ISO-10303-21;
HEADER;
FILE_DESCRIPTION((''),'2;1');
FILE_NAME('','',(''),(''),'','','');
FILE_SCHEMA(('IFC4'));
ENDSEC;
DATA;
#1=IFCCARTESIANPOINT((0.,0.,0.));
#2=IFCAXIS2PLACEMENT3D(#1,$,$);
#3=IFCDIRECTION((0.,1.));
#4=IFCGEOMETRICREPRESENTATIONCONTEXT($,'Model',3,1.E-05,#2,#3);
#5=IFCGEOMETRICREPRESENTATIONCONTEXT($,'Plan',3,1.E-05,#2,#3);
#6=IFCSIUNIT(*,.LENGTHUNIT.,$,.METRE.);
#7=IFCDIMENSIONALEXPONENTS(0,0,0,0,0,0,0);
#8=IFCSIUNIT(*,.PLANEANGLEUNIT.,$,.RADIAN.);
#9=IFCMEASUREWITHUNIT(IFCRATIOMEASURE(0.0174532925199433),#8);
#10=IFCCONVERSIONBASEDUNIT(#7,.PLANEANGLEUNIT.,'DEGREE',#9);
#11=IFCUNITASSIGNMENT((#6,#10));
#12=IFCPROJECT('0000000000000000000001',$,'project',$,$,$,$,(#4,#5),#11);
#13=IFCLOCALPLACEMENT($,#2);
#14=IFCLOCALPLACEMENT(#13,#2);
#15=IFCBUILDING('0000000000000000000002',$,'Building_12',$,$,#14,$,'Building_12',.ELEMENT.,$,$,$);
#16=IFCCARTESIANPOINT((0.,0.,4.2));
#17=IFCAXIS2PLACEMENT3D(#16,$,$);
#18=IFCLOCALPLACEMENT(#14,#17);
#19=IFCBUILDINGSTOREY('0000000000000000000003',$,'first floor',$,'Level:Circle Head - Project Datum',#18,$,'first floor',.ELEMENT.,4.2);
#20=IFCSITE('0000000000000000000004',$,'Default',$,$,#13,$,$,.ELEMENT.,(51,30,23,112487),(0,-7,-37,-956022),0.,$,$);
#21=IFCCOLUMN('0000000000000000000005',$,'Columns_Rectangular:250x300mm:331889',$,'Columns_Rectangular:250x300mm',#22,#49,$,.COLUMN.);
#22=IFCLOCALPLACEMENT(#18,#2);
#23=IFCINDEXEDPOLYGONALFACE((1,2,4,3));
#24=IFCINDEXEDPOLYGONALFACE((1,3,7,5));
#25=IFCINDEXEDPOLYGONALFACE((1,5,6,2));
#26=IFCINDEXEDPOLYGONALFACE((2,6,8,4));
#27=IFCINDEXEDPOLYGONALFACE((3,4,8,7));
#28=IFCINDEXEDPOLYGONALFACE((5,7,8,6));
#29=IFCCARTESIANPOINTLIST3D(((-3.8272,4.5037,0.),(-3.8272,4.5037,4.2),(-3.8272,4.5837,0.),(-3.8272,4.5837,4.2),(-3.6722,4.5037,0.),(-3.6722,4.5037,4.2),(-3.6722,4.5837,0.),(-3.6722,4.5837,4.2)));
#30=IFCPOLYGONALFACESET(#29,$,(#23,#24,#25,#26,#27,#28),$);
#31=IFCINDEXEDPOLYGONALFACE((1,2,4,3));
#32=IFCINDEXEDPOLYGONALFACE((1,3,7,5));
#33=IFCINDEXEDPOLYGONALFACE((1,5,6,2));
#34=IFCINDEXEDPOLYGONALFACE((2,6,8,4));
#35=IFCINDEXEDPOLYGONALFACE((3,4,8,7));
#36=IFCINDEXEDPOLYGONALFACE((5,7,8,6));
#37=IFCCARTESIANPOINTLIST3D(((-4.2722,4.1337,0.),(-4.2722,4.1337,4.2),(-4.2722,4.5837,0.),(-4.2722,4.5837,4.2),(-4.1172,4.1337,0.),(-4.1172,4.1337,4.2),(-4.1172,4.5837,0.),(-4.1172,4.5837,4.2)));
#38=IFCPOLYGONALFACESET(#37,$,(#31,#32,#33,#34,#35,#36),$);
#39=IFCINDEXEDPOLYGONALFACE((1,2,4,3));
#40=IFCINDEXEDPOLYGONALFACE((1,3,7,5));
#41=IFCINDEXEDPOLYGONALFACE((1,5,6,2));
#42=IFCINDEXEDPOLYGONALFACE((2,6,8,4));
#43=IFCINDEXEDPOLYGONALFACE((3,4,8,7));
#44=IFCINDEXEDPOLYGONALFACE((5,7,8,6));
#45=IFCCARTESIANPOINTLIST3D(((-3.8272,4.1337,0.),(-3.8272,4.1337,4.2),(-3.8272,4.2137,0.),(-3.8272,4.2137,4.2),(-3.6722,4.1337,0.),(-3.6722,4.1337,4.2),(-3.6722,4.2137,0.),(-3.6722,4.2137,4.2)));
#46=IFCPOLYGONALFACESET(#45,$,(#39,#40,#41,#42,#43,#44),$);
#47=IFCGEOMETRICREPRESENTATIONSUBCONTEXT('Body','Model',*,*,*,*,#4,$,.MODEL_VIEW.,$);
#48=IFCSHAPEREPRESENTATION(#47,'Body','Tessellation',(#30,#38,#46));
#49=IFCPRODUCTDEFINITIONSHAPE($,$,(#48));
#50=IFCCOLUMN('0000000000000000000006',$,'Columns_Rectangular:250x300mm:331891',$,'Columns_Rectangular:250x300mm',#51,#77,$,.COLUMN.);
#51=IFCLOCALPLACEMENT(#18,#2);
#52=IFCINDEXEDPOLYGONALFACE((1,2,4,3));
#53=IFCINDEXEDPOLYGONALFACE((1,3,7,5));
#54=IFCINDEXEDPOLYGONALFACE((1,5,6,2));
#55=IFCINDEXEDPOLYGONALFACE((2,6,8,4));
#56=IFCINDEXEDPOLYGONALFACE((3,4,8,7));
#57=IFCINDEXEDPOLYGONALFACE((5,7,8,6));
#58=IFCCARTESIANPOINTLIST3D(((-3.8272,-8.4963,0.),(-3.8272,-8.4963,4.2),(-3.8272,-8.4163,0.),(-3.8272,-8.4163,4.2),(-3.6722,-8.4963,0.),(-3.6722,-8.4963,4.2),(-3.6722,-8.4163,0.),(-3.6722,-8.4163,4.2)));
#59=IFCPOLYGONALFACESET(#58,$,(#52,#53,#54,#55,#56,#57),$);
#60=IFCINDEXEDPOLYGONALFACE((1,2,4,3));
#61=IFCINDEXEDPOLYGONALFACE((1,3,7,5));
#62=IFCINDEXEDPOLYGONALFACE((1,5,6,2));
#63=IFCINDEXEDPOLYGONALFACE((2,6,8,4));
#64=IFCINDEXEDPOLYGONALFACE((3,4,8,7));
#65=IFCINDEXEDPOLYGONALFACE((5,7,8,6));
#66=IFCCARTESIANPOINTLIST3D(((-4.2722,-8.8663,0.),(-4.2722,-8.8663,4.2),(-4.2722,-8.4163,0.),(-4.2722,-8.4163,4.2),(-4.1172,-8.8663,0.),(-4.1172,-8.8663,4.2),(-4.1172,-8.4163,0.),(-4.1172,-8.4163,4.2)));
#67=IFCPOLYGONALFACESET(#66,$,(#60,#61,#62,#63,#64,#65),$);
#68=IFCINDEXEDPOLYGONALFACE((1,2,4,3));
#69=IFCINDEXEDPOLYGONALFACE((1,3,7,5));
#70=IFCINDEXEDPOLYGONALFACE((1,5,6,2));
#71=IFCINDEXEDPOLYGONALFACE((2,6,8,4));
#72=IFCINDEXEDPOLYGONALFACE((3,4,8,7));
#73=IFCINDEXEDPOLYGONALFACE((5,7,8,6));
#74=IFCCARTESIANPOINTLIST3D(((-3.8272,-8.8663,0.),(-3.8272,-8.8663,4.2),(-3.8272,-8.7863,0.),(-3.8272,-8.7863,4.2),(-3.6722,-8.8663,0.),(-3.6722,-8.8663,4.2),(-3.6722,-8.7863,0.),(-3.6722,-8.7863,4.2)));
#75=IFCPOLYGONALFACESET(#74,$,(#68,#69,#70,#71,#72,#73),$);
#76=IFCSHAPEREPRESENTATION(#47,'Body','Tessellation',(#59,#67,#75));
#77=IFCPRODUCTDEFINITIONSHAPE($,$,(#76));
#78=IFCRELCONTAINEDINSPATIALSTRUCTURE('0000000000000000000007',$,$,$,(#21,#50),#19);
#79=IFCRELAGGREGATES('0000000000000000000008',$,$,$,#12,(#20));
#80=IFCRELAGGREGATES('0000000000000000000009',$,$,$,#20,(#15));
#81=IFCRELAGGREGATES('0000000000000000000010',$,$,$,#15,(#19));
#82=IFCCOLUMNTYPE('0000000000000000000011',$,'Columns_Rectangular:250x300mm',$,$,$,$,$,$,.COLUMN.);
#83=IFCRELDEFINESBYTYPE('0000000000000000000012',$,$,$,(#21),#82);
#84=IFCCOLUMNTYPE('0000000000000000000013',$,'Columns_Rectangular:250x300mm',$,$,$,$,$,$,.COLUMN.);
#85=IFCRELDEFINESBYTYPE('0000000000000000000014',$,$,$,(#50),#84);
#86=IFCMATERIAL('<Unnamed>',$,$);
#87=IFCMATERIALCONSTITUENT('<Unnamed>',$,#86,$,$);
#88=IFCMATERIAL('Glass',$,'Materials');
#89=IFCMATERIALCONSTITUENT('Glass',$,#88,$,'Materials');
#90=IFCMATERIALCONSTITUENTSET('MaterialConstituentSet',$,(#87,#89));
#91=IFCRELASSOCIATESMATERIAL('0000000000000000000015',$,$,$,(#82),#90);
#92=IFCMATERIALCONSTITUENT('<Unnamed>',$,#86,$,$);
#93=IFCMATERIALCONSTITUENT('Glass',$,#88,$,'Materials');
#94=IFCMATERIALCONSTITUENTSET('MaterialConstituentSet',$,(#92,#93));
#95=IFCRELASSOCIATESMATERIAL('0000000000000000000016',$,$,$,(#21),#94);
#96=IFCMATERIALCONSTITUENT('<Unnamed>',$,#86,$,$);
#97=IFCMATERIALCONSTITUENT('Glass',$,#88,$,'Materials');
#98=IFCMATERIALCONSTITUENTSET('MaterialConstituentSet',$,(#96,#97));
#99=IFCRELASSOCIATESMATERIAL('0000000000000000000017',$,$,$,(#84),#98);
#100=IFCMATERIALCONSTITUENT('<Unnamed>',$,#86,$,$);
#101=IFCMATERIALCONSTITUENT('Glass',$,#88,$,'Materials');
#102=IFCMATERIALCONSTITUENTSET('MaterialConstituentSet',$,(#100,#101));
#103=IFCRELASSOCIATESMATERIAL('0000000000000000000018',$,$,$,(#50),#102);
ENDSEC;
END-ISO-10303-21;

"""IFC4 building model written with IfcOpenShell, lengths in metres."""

from ifc_helpers import new_model, entity, si_unit, converted_unit, direction, frame, origin, place, context, subcontext, project, spatial, indexed_curve, outline, extrude, source, transform, mapped, material, constituent, constituent_set, type_object, type_shapes, element, save


model = new_model("IFC4")

# Units and contexts
model_context = context("Model", 3, precision=1e-05, world=origin(), true_north=direction((0.0, 1.0)))
plan_context = context("Plan", 3, precision=1e-05, world=origin(), true_north=direction((0.0, 1.0)))
body_context = subcontext(model_context, "Body", "Model", "MODEL_VIEW")
ifc_project = project(units=[si_unit("LENGTHUNIT", "METRE"), converted_unit("PLANEANGLEUNIT", "DEGREE", entity("IfcRatioMeasure", 0.0174532925199433), si_unit("PLANEANGLEUNIT", "RADIAN"), dimensions=[0, 0, 0, 0, 0, 0, 0])], contexts=[model_context, plan_context])

# Site, building, storey
site_placement = place(None, origin())
site = spatial("IfcSite", under=ifc_project, at=site_placement, Name="Default", CompositionType="ELEMENT", RefLatitude=(51, 30, 23, 112487), RefLongitude=(0, -7, -37, -956022), RefElevation=0.0)
building_placement = place(site_placement, origin())
building = spatial("IfcBuilding", under=site, at=building_placement, Name="Building_12", LongName="Building_12", CompositionType="ELEMENT")
storey_placement = place(building_placement, frame((0.0, 0.0, 4.2)))
storey = spatial("IfcBuildingStorey", under=building, at=storey_placement, Name="first floor", ObjectType="Level:Circle Head - Project Datum", LongName="first floor", CompositionType="ELEMENT", Elevation=4.2)

# Columns
ifc_material_1 = material(Name="<Unnamed>")
ifc_material_2 = material(Name="Glass", Category="Materials")
ifc_constituent_1 = constituent(ifc_material_1, Name="<Unnamed>")
ifc_constituent_2 = constituent(ifc_material_2, Name="Glass", Category="Materials")
ifc_constituent_set_1 = constituent_set(constituents=[ifc_constituent_1, ifc_constituent_2], Name="MaterialConstituentSet")
ifc_constituent_3 = constituent(ifc_material_1, Name="<Unnamed>")
ifc_constituent_4 = constituent(ifc_material_2, Name="Glass", Category="Materials")
ifc_constituent_set_2 = constituent_set(constituents=[ifc_constituent_3, ifc_constituent_4], Name="MaterialConstituentSet")
column_type_1 = type_object("IfcColumnType", Name="Columns_Rectangular:250x300mm", PredefinedType="COLUMN", material=ifc_constituent_set_2)
shared_shape_1 = source(origin(), body_context, "Body", "SweptSolid", [
    extrude(outline(indexed_curve([(-0.04, -0.0775), (0.04, -0.0775), (0.04, 0.0775), (-0.04, 0.0775), (-0.04, -0.0775)], self_intersect=False)), frame((-3.7497, 4.5437, 4.2), z_axis=(0.0, 0.0, 1.0), x_axis=(0.0, -1.0, 0.0)), (0.0, 0.0, 1.0), 4.2),
    extrude(outline(indexed_curve([(-0.225, -0.0775), (0.225, -0.0775), (0.225, 0.0775), (-0.225, 0.0775), (-0.225, -0.0775)], self_intersect=False)), frame((-4.1947, 4.3587, 4.2), z_axis=(0.0, 0.0, 1.0), x_axis=(0.0, -1.0, 0.0)), (0.0, 0.0, 1.0), 4.2),
    extrude(outline(indexed_curve([(-0.04, -0.0775), (0.04, -0.0775), (0.04, 0.0775), (-0.04, 0.0775), (-0.04, -0.0775)], self_intersect=False)), frame((-3.7497, 4.1737, 4.2), z_axis=(0.0, 0.0, 1.0), x_axis=(0.0, -1.0, 0.0)), (0.0, 0.0, 1.0), 4.2),
])
type_shapes(column_type_1, [shared_shape_1])
column_1_placement = place(storey_placement, frame((0.0, 0.0, -4.2)))
element("IfcColumn", 1, at=column_1_placement, inside=storey, type_object=column_type_1, material=ifc_constituent_set_1, Name="Columns_Rectangular:250x300mm:331889", ObjectType="Columns_Rectangular:250x300mm", PredefinedType="COLUMN", context=body_context, shape_type="MappedRepresentation", body=[
    mapped(shared_shape_1, transform((0.0, 0.0, 0.0), scale=1.0)),
])
ifc_constituent_5 = constituent(ifc_material_1, Name="<Unnamed>")
ifc_constituent_6 = constituent(ifc_material_2, Name="Glass", Category="Materials")
ifc_constituent_set_3 = constituent_set(constituents=[ifc_constituent_5, ifc_constituent_6], Name="MaterialConstituentSet")
ifc_constituent_7 = constituent(ifc_material_1, Name="<Unnamed>")
ifc_constituent_8 = constituent(ifc_material_2, Name="Glass", Category="Materials")
ifc_constituent_set_4 = constituent_set(constituents=[ifc_constituent_7, ifc_constituent_8], Name="MaterialConstituentSet")
column_type_2 = type_object("IfcColumnType", Name="Columns_Rectangular:250x300mm", PredefinedType="COLUMN", material=ifc_constituent_set_4)
shared_shape_2 = source(origin(), body_context, "Body", "SweptSolid", [
    extrude(outline(indexed_curve([(-0.04, -0.0775), (0.04, -0.0775), (0.04, 0.0775), (-0.04, 0.0775), (-0.04, -0.0775)], self_intersect=False)), frame((-3.7497, -8.4563, 4.2), z_axis=(0.0, 0.0, 1.0), x_axis=(0.0, -1.0, 0.0)), (0.0, 0.0, 1.0), 4.2),
    extrude(outline(indexed_curve([(-0.225, -0.0775), (0.225, -0.0775), (0.225, 0.0775), (-0.225, 0.0775), (-0.225, -0.0775)], self_intersect=False)), frame((-4.1947, -8.6413, 4.2), z_axis=(0.0, 0.0, 1.0), x_axis=(0.0, -1.0, 0.0)), (0.0, 0.0, 1.0), 4.2),
    extrude(outline(indexed_curve([(-0.04, -0.0775), (0.04, -0.0775), (0.04, 0.0775), (-0.04, 0.0775), (-0.04, -0.0775)], self_intersect=False)), frame((-3.7497, -8.8263, 4.2), z_axis=(0.0, 0.0, 1.0), x_axis=(0.0, -1.0, 0.0)), (0.0, 0.0, 1.0), 4.2),
])
type_shapes(column_type_2, [shared_shape_2])
column_2_placement = place(storey_placement, frame((0.0, 0.0, -4.2)))
element("IfcColumn", 2, at=column_2_placement, inside=storey, type_object=column_type_2, material=ifc_constituent_set_3, Name="Columns_Rectangular:250x300mm:331891", ObjectType="Columns_Rectangular:250x300mm", PredefinedType="COLUMN", context=body_context, shape_type="MappedRepresentation", body=[
    mapped(shared_shape_2, transform((0.0, 0.0, 0.0), scale=1.0)),
])

save(model, "model.ifc")
